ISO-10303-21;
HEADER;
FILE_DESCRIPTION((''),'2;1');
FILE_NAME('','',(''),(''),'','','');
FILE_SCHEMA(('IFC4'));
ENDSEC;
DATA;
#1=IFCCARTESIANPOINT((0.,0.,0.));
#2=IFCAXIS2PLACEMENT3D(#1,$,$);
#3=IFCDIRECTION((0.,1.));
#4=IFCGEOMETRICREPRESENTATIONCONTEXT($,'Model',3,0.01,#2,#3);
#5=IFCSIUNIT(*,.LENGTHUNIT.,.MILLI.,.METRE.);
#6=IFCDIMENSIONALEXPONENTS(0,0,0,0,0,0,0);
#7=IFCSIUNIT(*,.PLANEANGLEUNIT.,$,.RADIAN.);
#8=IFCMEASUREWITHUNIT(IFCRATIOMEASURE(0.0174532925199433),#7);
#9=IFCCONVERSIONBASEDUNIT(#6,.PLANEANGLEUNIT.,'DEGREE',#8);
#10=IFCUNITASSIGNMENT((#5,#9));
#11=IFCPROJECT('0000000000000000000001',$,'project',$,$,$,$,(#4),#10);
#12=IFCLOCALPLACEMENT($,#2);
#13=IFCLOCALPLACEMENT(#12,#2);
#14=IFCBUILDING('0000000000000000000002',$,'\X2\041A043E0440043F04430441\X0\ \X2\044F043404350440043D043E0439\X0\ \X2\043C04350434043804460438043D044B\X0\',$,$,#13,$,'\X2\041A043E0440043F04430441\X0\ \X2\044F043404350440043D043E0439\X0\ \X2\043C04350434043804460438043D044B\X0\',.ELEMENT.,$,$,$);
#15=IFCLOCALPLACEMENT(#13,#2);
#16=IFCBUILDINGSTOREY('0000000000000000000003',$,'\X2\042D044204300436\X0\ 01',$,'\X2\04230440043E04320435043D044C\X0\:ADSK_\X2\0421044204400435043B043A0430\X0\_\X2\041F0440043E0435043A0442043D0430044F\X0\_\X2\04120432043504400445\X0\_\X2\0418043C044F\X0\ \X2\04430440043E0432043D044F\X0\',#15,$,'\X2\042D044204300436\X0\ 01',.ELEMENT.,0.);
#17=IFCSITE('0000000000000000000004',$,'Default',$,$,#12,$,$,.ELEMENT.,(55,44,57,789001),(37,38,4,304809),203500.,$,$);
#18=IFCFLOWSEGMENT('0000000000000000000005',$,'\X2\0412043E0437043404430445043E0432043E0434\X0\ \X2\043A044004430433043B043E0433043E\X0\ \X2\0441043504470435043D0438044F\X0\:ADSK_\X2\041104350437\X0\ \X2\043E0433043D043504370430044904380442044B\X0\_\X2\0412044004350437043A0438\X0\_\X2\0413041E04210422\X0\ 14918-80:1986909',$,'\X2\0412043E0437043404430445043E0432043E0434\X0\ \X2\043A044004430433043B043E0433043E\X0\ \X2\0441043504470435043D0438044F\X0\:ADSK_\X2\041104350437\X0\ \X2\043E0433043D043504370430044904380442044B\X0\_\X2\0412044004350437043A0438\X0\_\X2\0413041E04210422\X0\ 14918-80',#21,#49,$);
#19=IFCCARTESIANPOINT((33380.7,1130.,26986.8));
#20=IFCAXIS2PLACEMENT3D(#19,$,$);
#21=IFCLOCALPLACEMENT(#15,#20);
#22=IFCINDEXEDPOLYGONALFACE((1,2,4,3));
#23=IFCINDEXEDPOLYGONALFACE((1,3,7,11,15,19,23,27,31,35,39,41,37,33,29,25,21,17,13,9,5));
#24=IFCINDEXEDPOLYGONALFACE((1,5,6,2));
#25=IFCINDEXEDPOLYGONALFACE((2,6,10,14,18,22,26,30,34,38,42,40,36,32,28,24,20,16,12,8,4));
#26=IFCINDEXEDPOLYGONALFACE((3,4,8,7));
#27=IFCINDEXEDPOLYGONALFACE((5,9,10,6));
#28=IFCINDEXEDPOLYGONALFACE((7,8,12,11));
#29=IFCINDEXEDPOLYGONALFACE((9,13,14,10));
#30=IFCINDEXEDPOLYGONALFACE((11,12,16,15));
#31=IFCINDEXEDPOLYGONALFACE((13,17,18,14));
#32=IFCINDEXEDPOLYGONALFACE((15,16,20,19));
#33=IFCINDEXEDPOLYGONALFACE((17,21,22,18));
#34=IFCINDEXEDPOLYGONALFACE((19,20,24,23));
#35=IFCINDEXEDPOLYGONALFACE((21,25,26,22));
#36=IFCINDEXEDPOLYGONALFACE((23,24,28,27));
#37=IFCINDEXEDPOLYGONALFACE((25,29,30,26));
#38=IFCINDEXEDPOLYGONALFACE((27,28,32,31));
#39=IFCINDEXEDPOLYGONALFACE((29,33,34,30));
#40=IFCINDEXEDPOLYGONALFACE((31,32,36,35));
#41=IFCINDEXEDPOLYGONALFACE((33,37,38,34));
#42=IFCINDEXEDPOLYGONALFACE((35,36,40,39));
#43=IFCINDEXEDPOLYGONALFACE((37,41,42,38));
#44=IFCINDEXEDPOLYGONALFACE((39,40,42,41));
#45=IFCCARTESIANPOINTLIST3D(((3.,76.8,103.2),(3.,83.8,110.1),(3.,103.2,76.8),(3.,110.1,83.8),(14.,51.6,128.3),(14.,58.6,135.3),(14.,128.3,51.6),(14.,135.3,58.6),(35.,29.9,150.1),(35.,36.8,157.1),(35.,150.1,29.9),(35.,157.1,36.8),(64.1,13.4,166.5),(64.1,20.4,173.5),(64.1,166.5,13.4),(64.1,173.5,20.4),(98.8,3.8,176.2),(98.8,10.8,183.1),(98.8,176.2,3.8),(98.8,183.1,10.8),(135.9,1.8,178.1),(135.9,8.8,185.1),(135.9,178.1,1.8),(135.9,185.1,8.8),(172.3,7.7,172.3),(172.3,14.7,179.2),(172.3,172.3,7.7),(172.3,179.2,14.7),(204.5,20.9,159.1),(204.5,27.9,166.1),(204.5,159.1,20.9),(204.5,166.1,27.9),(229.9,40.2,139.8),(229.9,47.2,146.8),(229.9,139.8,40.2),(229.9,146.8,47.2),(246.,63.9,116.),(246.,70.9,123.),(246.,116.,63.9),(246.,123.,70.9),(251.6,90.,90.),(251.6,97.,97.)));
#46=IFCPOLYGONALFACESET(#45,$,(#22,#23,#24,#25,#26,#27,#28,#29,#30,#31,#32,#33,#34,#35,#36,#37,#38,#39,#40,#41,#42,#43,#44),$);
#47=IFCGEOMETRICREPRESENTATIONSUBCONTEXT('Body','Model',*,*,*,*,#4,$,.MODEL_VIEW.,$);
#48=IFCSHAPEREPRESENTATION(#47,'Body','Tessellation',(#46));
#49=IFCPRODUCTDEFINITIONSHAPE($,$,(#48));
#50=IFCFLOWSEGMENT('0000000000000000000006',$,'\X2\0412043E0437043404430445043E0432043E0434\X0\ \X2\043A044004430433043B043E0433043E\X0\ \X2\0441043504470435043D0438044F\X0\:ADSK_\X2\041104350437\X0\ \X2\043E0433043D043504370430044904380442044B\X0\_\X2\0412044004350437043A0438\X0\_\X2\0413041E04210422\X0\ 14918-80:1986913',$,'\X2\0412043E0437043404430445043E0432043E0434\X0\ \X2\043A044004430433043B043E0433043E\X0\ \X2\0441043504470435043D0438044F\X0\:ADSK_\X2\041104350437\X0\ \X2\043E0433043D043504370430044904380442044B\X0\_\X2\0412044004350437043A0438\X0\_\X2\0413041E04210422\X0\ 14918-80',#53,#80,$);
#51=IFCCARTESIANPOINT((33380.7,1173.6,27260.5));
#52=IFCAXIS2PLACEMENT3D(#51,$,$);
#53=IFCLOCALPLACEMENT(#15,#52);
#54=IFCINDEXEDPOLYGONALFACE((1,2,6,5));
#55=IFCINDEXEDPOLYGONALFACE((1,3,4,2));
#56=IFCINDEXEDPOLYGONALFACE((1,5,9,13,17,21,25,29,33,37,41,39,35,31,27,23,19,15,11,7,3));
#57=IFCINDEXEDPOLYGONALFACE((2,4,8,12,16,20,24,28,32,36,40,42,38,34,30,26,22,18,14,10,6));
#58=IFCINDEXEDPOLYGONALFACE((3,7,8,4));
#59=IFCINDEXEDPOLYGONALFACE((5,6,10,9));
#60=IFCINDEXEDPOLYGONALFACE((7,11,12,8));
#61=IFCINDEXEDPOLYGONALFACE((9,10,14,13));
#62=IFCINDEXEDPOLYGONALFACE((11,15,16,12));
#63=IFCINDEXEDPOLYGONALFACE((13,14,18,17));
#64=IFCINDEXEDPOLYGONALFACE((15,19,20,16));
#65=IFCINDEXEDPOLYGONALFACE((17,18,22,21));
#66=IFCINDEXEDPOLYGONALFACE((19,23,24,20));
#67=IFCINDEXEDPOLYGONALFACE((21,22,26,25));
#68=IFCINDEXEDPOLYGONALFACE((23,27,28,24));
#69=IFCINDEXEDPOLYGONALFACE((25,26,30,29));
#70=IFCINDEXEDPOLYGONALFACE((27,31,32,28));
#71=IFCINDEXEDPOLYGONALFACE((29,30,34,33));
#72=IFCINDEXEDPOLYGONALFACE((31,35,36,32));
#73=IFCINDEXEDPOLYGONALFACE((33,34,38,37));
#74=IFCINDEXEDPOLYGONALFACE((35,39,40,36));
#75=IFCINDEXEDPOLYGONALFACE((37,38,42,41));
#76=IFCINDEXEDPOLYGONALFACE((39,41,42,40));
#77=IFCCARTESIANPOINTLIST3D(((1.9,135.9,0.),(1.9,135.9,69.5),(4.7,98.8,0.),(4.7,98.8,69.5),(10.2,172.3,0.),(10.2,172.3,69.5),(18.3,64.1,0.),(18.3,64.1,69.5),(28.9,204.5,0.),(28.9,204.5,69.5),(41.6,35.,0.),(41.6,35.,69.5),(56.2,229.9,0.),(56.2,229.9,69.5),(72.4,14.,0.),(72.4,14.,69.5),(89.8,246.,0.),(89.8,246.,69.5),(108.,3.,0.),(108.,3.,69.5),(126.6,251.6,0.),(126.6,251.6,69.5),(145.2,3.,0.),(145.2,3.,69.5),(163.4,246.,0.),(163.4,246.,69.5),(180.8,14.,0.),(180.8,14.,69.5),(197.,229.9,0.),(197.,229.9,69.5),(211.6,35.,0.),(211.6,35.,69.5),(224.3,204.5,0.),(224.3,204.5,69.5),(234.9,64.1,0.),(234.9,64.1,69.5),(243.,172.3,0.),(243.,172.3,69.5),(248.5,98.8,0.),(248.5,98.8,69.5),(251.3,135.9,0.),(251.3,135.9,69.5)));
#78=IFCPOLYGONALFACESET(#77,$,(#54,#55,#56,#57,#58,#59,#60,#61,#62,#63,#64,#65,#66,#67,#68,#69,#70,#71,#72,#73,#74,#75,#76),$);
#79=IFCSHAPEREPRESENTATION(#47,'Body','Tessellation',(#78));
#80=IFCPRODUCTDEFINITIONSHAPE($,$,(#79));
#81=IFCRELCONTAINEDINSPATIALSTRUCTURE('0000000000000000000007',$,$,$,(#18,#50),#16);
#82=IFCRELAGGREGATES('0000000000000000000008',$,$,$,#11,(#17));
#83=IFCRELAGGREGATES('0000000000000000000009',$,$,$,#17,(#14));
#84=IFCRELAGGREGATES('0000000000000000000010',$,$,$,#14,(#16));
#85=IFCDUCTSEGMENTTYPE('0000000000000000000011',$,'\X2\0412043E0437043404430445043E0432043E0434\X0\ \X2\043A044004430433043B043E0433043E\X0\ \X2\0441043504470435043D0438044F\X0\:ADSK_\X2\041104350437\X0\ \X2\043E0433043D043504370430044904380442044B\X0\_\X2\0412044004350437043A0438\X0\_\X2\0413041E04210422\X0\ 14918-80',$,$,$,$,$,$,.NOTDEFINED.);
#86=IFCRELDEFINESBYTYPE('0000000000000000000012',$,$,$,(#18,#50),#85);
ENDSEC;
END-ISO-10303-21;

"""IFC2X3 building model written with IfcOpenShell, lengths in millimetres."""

from ifc_helpers import new_model, entity, si_unit, converted_unit, direction, frame, origin, origin_2d_with_axis, place, context, subcontext, project, spatial, circle, extrude, type_object, element, save


model = new_model("IFC2X3")

# Units and contexts
model_context = context("Model", 3, precision=0.01, world=origin(), true_north=direction((0.0, 1.0)))
body_context = subcontext(model_context, "Body", "Model", "MODEL_VIEW")
ifc_project = project(units=[si_unit("LENGTHUNIT", "METRE", prefix="MILLI"), converted_unit("PLANEANGLEUNIT", "DEGREE", entity("IfcRatioMeasure", 0.0174532925199433), si_unit("PLANEANGLEUNIT", "RADIAN"), dimensions=[0, 0, 0, 0, 0, 0, 0])], contexts=[model_context])

# Site, building, storey
site_placement = place(None, origin())
site = spatial("IfcSite", under=ifc_project, at=site_placement, Name="Default", CompositionType="ELEMENT", RefLatitude=(55, 44, 57, 789001), RefLongitude=(37, 38, 4, 304809), RefElevation=203500.0)
building_placement = place(site_placement, origin())
building = spatial("IfcBuilding", under=site, at=building_placement, Name="Корпус ядерной медицины", LongName="Корпус ядерной медицины", CompositionType="ELEMENT")
storey_placement = place(building_placement, origin())
storey = spatial("IfcBuildingStorey", under=building, at=storey_placement, Name="Этаж 01", ObjectType="Уровень:ADSK_Стрелка_Проектная_Вверх_Имя уровня", LongName="Этаж 01", CompositionType="ELEMENT", Elevation=0.0)

# Flow segments
duct_segment_type_1 = type_object("IfcDuctSegmentType", Name="Воздуховод круглого сечения:ADSK_Без огнезащиты_Врезки_ГОСТ 14918-80", PredefinedType="NOTDEFINED")
flow_segment_1_placement = place(storey_placement, frame((33380.7, 1130.0, 26986.8)))
element("IfcFlowSegment", 1, at=flow_segment_1_placement, inside=storey, type_object=duct_segment_type_1, Name="Воздуховод круглого сечения:ADSK_Без огнезащиты_Врезки_ГОСТ 14918-80:1986909", ObjectType="Воздуховод круглого сечения:ADSK_Без огнезащиты_Врезки_ГОСТ 14918-80", context=body_context, shape_type="SweptSolid", body=[
    extrude(circle(Radius=125.0, at=origin_2d_with_axis()), frame((126.6, 90.0, 90.0), z_axis=(0.0, 0.707107, 0.707107), x_axis=(1.0, 0.0, 0.0)), (0.0, 0.0, 1.0), 9.9),
])
flow_segment_2_placement = place(storey_placement, frame((33380.7, 1173.6, 27260.5)))
element("IfcFlowSegment", 2, at=flow_segment_2_placement, inside=storey, type_object=duct_segment_type_1, Name="Воздуховод круглого сечения:ADSK_Без огнезащиты_Врезки_ГОСТ 14918-80:1986913", ObjectType="Воздуховод круглого сечения:ADSK_Без огнезащиты_Врезки_ГОСТ 14918-80", context=body_context, shape_type="SweptSolid", body=[
    extrude(circle(Radius=125.0, at=origin_2d_with_axis()), frame((126.6, 126.6, 0.0), z_axis=(0.0, 0.0, 1.0), x_axis=(0.0, 1.0, 0.0)), (0.0, 0.0, 1.0), 69.5),
])

save(model, "model.ifc")
